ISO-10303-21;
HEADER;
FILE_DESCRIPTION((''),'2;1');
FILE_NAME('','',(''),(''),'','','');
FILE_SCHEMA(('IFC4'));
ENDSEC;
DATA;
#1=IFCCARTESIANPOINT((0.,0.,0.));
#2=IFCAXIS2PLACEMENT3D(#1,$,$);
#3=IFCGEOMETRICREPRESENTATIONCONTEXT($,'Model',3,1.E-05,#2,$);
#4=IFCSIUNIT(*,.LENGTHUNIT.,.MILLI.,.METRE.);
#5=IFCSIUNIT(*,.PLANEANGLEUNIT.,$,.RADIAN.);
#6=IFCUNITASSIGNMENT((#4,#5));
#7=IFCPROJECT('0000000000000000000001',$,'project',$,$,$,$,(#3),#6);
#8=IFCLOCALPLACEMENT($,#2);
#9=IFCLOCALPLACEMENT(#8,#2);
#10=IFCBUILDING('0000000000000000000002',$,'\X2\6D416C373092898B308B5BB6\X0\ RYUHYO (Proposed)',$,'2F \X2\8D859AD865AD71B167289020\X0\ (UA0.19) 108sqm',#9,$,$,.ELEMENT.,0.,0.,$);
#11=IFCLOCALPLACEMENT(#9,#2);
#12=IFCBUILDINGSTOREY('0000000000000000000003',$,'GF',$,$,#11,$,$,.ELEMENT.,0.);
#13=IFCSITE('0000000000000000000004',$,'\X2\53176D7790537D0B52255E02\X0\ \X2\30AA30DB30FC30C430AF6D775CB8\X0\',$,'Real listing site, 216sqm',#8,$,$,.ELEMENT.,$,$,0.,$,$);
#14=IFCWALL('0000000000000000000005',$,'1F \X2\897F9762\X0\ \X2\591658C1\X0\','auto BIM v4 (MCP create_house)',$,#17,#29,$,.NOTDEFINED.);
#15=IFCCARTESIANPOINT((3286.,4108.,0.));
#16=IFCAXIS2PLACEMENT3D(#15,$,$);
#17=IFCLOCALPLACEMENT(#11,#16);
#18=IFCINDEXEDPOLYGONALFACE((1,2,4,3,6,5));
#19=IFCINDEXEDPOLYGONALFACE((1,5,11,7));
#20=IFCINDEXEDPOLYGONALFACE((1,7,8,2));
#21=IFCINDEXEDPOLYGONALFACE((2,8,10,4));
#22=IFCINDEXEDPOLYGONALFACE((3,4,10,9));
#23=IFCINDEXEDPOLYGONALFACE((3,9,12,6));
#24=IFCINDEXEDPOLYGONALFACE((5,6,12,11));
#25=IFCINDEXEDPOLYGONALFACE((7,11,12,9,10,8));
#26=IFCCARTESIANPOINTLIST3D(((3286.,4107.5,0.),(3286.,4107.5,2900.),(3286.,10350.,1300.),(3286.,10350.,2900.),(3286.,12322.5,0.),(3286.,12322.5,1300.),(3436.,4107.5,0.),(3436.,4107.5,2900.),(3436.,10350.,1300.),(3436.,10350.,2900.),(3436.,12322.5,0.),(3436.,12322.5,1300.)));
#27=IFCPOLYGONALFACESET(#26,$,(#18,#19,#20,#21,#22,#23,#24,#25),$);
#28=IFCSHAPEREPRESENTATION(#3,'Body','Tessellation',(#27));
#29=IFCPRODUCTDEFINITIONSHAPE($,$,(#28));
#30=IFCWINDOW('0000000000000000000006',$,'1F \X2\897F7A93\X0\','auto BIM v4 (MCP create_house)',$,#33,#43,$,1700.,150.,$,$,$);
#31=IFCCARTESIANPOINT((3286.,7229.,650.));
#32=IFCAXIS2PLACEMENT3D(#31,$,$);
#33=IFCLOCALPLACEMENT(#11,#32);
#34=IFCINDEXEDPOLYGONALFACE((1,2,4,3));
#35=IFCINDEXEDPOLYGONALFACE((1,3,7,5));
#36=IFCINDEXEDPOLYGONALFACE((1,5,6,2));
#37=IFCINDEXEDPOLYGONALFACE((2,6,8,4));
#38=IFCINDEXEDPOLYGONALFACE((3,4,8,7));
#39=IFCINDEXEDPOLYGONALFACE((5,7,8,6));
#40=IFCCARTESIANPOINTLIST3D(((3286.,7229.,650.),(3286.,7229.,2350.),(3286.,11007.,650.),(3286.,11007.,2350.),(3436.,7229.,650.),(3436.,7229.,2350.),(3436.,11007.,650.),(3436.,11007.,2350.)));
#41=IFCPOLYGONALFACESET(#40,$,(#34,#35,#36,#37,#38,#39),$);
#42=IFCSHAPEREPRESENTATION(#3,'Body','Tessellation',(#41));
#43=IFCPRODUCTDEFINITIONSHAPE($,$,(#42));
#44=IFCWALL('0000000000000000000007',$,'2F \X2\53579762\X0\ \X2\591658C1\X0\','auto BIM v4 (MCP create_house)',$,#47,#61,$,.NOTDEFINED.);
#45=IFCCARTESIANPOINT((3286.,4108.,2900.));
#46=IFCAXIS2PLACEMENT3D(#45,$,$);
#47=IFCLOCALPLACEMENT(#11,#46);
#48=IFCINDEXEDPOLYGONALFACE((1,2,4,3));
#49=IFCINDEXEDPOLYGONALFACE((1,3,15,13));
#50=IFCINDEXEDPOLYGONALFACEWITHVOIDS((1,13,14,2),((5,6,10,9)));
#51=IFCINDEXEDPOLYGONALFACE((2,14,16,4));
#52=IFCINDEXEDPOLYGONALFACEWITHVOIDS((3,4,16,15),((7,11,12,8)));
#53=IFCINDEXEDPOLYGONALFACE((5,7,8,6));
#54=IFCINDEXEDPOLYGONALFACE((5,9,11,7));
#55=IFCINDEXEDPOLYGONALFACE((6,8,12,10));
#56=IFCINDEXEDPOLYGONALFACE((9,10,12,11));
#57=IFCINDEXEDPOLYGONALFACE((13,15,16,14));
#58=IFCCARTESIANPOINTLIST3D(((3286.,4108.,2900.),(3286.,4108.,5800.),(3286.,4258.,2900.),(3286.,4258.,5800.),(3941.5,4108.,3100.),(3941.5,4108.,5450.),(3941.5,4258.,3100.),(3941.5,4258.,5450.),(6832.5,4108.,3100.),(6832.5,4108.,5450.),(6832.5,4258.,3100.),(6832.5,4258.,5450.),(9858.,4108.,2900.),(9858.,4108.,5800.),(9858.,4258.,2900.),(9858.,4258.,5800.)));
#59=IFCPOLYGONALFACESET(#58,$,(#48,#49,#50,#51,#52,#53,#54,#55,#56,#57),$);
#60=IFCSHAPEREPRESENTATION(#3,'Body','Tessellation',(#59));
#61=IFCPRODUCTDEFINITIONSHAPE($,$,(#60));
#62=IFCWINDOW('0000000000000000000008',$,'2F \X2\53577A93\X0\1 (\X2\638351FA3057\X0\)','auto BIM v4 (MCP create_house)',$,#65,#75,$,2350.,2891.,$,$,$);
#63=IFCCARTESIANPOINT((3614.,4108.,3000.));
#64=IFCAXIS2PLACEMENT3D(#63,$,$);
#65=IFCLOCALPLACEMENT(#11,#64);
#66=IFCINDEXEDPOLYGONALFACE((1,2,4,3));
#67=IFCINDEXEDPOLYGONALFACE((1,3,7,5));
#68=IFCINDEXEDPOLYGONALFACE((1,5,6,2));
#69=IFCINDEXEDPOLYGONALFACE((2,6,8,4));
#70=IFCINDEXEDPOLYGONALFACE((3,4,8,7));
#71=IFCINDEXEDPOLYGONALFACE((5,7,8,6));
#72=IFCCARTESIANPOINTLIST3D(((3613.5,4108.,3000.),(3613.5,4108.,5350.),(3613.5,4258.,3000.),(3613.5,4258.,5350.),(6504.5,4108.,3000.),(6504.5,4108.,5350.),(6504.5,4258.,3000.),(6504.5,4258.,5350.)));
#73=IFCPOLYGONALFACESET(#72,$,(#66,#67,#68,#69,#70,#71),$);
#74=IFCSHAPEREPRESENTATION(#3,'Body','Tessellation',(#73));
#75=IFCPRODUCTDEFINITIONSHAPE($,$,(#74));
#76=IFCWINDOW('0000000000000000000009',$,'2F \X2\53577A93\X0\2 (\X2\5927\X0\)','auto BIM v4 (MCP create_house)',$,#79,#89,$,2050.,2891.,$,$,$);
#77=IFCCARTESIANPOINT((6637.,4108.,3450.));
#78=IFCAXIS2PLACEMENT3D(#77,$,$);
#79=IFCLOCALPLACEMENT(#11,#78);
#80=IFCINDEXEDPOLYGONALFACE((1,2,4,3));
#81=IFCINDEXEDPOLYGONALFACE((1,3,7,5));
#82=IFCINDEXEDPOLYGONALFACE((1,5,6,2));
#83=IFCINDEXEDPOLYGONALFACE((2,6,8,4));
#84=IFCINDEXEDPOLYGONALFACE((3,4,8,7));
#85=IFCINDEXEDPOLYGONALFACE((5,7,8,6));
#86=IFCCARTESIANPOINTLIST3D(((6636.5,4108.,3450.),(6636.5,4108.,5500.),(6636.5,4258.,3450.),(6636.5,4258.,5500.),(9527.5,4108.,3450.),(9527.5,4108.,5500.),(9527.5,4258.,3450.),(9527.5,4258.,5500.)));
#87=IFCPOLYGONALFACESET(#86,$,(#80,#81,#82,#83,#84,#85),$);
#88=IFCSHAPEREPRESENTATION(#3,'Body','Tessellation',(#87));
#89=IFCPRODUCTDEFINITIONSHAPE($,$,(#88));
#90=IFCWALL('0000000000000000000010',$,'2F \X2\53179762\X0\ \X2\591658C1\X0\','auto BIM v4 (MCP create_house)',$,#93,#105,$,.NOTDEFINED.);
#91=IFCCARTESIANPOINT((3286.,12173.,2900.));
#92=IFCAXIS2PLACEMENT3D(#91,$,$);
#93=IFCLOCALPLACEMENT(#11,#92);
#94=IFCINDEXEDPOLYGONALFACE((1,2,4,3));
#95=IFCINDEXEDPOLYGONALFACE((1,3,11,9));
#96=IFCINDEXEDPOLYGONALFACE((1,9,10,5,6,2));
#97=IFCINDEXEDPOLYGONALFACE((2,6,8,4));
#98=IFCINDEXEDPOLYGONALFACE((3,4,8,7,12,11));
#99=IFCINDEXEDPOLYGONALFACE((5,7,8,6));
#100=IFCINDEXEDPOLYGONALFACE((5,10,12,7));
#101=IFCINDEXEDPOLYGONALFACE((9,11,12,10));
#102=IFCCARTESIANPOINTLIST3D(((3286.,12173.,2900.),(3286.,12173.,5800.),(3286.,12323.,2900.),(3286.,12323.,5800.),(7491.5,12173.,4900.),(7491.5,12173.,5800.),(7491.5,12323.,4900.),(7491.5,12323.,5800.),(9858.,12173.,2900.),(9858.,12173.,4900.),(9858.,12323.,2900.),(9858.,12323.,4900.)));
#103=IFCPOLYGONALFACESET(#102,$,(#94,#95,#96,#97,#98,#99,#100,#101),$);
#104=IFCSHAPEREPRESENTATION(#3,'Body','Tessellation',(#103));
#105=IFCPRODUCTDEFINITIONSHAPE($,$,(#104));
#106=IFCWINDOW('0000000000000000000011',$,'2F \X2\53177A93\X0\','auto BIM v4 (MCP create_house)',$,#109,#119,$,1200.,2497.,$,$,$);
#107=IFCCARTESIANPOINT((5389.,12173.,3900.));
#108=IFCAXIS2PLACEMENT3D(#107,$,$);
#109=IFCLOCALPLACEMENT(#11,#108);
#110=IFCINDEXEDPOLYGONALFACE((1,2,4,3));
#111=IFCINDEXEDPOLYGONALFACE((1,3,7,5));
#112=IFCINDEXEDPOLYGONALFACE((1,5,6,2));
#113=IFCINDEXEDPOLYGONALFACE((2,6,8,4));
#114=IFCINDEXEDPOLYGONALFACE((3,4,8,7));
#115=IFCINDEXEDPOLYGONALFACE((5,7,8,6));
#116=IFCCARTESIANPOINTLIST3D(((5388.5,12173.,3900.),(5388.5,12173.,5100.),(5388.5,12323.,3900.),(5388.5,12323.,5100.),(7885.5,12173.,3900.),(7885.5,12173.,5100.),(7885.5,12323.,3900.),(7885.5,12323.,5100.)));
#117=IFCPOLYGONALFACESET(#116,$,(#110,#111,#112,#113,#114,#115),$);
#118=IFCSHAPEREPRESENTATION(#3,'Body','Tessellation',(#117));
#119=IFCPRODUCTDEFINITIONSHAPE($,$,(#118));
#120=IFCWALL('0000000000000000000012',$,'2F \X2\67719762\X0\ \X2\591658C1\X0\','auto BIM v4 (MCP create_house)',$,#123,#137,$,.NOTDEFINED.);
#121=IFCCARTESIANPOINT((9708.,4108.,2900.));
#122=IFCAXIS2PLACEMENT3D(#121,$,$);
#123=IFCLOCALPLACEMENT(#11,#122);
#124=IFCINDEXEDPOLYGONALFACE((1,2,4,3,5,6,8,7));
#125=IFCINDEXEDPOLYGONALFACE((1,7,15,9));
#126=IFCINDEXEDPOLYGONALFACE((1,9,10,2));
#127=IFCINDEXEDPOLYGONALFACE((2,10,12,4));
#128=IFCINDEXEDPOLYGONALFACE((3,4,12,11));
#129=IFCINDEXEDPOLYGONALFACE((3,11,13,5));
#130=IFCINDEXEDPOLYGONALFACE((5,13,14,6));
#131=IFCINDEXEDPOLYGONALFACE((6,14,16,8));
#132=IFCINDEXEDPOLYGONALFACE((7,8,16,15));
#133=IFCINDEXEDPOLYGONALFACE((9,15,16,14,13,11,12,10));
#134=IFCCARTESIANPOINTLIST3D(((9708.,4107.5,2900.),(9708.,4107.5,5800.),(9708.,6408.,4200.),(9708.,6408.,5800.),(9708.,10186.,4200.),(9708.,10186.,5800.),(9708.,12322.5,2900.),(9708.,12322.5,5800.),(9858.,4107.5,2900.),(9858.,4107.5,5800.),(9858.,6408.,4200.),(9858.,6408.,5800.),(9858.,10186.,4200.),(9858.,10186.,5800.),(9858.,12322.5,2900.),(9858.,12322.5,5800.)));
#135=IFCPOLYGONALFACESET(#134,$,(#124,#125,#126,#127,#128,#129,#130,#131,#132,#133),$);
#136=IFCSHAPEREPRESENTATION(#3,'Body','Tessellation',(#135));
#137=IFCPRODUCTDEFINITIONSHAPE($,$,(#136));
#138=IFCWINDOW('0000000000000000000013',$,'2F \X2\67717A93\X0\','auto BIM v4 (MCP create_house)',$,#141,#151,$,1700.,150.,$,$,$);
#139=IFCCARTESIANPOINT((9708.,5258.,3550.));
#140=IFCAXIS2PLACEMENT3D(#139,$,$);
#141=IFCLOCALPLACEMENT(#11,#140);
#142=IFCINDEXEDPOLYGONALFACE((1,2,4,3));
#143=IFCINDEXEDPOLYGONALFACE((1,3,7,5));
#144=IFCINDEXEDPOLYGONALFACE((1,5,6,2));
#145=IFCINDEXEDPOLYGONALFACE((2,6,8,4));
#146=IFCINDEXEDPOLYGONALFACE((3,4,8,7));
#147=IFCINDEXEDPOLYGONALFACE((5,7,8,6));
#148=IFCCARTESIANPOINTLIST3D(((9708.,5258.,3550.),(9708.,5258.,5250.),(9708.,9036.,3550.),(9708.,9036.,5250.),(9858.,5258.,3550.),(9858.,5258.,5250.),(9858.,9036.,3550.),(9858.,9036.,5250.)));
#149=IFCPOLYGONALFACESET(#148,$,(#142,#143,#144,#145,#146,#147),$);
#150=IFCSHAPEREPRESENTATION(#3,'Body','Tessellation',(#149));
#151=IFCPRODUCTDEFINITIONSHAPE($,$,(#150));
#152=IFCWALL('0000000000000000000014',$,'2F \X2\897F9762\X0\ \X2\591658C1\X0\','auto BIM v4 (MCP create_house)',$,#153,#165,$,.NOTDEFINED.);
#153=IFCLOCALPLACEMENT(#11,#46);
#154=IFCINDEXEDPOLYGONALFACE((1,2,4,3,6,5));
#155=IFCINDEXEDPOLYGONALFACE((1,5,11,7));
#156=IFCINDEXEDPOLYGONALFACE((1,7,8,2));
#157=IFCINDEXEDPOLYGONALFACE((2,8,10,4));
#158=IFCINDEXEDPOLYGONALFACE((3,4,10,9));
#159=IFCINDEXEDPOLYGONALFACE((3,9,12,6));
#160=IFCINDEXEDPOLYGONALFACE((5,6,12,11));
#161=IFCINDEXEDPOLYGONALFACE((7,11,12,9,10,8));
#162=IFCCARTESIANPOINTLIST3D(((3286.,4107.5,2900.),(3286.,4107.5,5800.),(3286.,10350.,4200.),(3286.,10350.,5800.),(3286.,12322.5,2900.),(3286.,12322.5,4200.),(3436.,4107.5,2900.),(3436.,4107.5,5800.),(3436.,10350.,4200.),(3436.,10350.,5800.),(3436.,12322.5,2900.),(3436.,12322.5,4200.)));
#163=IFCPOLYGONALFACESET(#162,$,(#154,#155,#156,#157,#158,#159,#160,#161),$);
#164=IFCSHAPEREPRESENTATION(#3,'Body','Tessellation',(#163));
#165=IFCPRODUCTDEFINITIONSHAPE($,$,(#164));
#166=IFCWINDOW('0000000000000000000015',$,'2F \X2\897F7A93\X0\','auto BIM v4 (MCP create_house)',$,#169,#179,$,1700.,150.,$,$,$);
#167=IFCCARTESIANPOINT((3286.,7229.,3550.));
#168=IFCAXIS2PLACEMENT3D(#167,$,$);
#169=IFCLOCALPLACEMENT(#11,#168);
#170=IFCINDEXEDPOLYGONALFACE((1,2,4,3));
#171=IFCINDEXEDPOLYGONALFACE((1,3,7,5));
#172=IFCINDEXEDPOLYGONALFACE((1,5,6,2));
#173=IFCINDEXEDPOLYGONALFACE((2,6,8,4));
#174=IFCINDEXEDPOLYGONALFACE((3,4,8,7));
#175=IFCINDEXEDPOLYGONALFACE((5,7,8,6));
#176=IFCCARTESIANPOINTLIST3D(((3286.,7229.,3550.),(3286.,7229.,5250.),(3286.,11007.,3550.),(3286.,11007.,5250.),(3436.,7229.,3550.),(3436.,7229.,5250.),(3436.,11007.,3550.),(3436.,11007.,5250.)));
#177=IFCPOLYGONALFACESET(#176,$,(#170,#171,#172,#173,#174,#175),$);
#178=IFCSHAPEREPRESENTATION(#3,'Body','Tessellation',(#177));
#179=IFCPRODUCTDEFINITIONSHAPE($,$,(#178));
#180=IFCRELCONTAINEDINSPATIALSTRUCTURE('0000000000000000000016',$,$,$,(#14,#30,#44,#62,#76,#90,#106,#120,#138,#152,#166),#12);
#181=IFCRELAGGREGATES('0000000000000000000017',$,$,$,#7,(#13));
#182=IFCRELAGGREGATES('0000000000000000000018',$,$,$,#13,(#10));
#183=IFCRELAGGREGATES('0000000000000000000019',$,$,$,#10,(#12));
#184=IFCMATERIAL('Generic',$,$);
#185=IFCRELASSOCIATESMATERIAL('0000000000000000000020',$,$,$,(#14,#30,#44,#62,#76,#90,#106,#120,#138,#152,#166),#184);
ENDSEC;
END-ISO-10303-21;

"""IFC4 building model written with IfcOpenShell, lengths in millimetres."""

from ifc_helpers import new_model, si_unit, frame, frame_2d, origin, place, context, project, spatial, rectangle, extrude, material, element, fill, save


model = new_model("IFC4")

# Units and contexts
model_context = context("Model", 3, precision=1e-05, world=origin())
ifc_project = project(units=[si_unit("LENGTHUNIT", "METRE", prefix="MILLI"), si_unit("PLANEANGLEUNIT", "RADIAN")], contexts=[model_context])

# Site, building, storey
site_placement = place(None, origin())
site = spatial("IfcSite", under=ifc_project, at=site_placement, Name="北海道紋別市 オホーツク海岸", ObjectType="Real listing site, 216sqm", CompositionType="ELEMENT", RefElevation=0.0)
building_placement = place(site_placement, origin())
building = spatial("IfcBuilding", under=site, at=building_placement, Name="流氷を見る家 RYUHYO (Proposed)", ObjectType="2F 超高断熱木造 (UA0.19) 108sqm", CompositionType="ELEMENT", ElevationOfRefHeight=0.0, ElevationOfTerrain=0.0)
storey_placement = place(building_placement, origin())
storey = spatial("IfcBuildingStorey", under=building, at=storey_placement, Name="GF", CompositionType="ELEMENT", Elevation=0.0)

# Shared definitions
ifc_material = material(Name="Generic")

# Wall, opening, window
wall_1_placement = place(storey_placement, frame((3286.0, 4108.0, 0.0)))
wall_1 = element("IfcWall", 1, at=wall_1_placement, inside=storey, material=ifc_material, Name="1F 西面 外壁", Description="auto BIM v4 (MCP create_house)", PredefinedType="NOTDEFINED", context=model_context, shape_type="SweptSolid", body=[
    extrude(rectangle(XDim=150.0, YDim=8215.0, at=frame_2d((75.0, 4107.0))), frame((3286.0, 4108.0, 0.0)), (0.0, 0.0, 1.0), 2900.0),
])
opening_1_placement = place(storey_placement, frame((3286.0, 7229.0, 650.0)))
opening_1 = element("IfcOpeningElement", 2, at=opening_1_placement, cuts=wall_1, PredefinedType="NOTDEFINED", context=model_context, shape_type="SweptSolid", body=[
    extrude(rectangle(XDim=150.0, YDim=3778.0, at=frame_2d((75.0, 1889.0))), frame((3286.0, 7229.0, 650.0)), (0.0, 0.0, 1.0), 1700.0),
])
window_1_placement = place(storey_placement, frame((3286.0, 7229.0, 650.0)))
window_1 = element("IfcWindow", 3, at=window_1_placement, inside=storey, material=ifc_material, Name="1F 西窓", Description="auto BIM v4 (MCP create_house)", OverallHeight=1700.0, OverallWidth=150.0, context=model_context, shape_type="SweptSolid", body=[
    extrude(rectangle(XDim=150.0, YDim=3778.0, at=frame_2d((75.0, 1889.0))), frame((3286.0, 7229.0, 650.0)), (0.0, 0.0, 1.0), 1700.0),
])
fill(opening_1, window_1)

# Wall, openings, windows
wall_2_placement = place(storey_placement, frame((3286.0, 4108.0, 2900.0)))
wall_2 = element("IfcWall", 4, at=wall_2_placement, inside=storey, material=ifc_material, Name="2F 南面 外壁", Description="auto BIM v4 (MCP create_house)", PredefinedType="NOTDEFINED", context=model_context, shape_type="SweptSolid", body=[
    extrude(rectangle(XDim=6572.0, YDim=150.0, at=frame_2d((3286.0, 75.0))), frame((3286.0, 4108.0, 2900.0)), (0.0, 0.0, 1.0), 2900.0),
])
opening_2_placement = place(storey_placement, frame((3614.0, 4108.0, 3000.0)))
opening_2 = element("IfcOpeningElement", 5, at=opening_2_placement, cuts=wall_2, PredefinedType="NOTDEFINED", context=model_context, shape_type="SweptSolid", body=[
    extrude(rectangle(XDim=2891.0, YDim=150.0, at=frame_2d((1445.0, 75.0))), frame((3614.0, 4108.0, 3000.0)), (0.0, 0.0, 1.0), 2350.0),
])
opening_3_placement = place(storey_placement, frame((6637.0, 4108.0, 3450.0)))
opening_3 = element("IfcOpeningElement", 6, at=opening_3_placement, cuts=wall_2, PredefinedType="NOTDEFINED", context=model_context, shape_type="SweptSolid", body=[
    extrude(rectangle(XDim=2891.0, YDim=150.0, at=frame_2d((1445.0, 75.0))), frame((6637.0, 4108.0, 3450.0)), (0.0, 0.0, 1.0), 2050.0),
])
window_2_placement = place(storey_placement, frame((3614.0, 4108.0, 3000.0)))
window_2 = element("IfcWindow", 7, at=window_2_placement, inside=storey, material=ifc_material, Name="2F 南窓1 (掃出し)", Description="auto BIM v4 (MCP create_house)", OverallHeight=2350.0, OverallWidth=2891.0, context=model_context, shape_type="SweptSolid", body=[
    extrude(rectangle(XDim=2891.0, YDim=150.0, at=frame_2d((1445.0, 75.0))), frame((3614.0, 4108.0, 3000.0)), (0.0, 0.0, 1.0), 2350.0),
])
fill(opening_2, window_2)
window_3_placement = place(storey_placement, frame((6637.0, 4108.0, 3450.0)))
window_3 = element("IfcWindow", 8, at=window_3_placement, inside=storey, material=ifc_material, Name="2F 南窓2 (大)", Description="auto BIM v4 (MCP create_house)", OverallHeight=2050.0, OverallWidth=2891.0, context=model_context, shape_type="SweptSolid", body=[
    extrude(rectangle(XDim=2891.0, YDim=150.0, at=frame_2d((1445.0, 75.0))), frame((6637.0, 4108.0, 3450.0)), (0.0, 0.0, 1.0), 2050.0),
])
fill(opening_3, window_3)

# Walls, openings, windows
wall_3_placement = place(storey_placement, frame((3286.0, 12173.0, 2900.0)))
wall_3 = element("IfcWall", 9, at=wall_3_placement, inside=storey, material=ifc_material, Name="2F 北面 外壁", Description="auto BIM v4 (MCP create_house)", PredefinedType="NOTDEFINED", context=model_context, shape_type="SweptSolid", body=[
    extrude(rectangle(XDim=6572.0, YDim=150.0, at=frame_2d((3286.0, 75.0))), frame((3286.0, 12173.0, 2900.0)), (0.0, 0.0, 1.0), 2900.0),
])
opening_4_placement = place(storey_placement, frame((5389.0, 12173.0, 3900.0)))
opening_4 = element("IfcOpeningElement", 10, at=opening_4_placement, cuts=wall_3, PredefinedType="NOTDEFINED", context=model_context, shape_type="SweptSolid", body=[
    extrude(rectangle(XDim=2497.0, YDim=150.0, at=frame_2d((1248.0, 75.0))), frame((5389.0, 12173.0, 3900.0)), (0.0, 0.0, 1.0), 1200.0),
])
window_4_placement = place(storey_placement, frame((5389.0, 12173.0, 3900.0)))
window_4 = element("IfcWindow", 11, at=window_4_placement, inside=storey, material=ifc_material, Name="2F 北窓", Description="auto BIM v4 (MCP create_house)", OverallHeight=1200.0, OverallWidth=2497.0, context=model_context, shape_type="SweptSolid", body=[
    extrude(rectangle(XDim=2497.0, YDim=150.0, at=frame_2d((1248.0, 75.0))), frame((5389.0, 12173.0, 3900.0)), (0.0, 0.0, 1.0), 1200.0),
])
fill(opening_4, window_4)
wall_4_placement = place(storey_placement, frame((9708.0, 4108.0, 2900.0)))
wall_4 = element("IfcWall", 12, at=wall_4_placement, inside=storey, material=ifc_material, Name="2F 東面 外壁", Description="auto BIM v4 (MCP create_house)", PredefinedType="NOTDEFINED", context=model_context, shape_type="SweptSolid", body=[
    extrude(rectangle(XDim=150.0, YDim=8215.0, at=frame_2d((75.0, 4107.0))), frame((9708.0, 4108.0, 2900.0)), (0.0, 0.0, 1.0), 2900.0),
])
opening_5_placement = place(storey_placement, frame((9708.0, 5258.0, 3550.0)))
opening_5 = element("IfcOpeningElement", 13, at=opening_5_placement, cuts=wall_4, PredefinedType="NOTDEFINED", context=model_context, shape_type="SweptSolid", body=[
    extrude(rectangle(XDim=150.0, YDim=3778.0, at=frame_2d((75.0, 1889.0))), frame((9708.0, 5258.0, 3550.0)), (0.0, 0.0, 1.0), 1700.0),
])
window_5_placement = place(storey_placement, frame((9708.0, 5258.0, 3550.0)))
window_5 = element("IfcWindow", 14, at=window_5_placement, inside=storey, material=ifc_material, Name="2F 東窓", Description="auto BIM v4 (MCP create_house)", OverallHeight=1700.0, OverallWidth=150.0, context=model_context, shape_type="SweptSolid", body=[
    extrude(rectangle(XDim=150.0, YDim=3778.0, at=frame_2d((75.0, 1889.0))), frame((9708.0, 5258.0, 3550.0)), (0.0, 0.0, 1.0), 1700.0),
])
fill(opening_5, window_5)
wall_5_placement = place(storey_placement, frame((3286.0, 4108.0, 2900.0)))
wall_5 = element("IfcWall", 15, at=wall_5_placement, inside=storey, material=ifc_material, Name="2F 西面 外壁", Description="auto BIM v4 (MCP create_house)", PredefinedType="NOTDEFINED", context=model_context, shape_type="SweptSolid", body=[
    extrude(rectangle(XDim=150.0, YDim=8215.0, at=frame_2d((75.0, 4107.0))), frame((3286.0, 4108.0, 2900.0)), (0.0, 0.0, 1.0), 2900.0),
])
opening_6_placement = place(storey_placement, frame((3286.0, 7229.0, 3550.0)))
opening_6 = element("IfcOpeningElement", 16, at=opening_6_placement, cuts=wall_5, PredefinedType="NOTDEFINED", context=model_context, shape_type="SweptSolid", body=[
    extrude(rectangle(XDim=150.0, YDim=3778.0, at=frame_2d((75.0, 1889.0))), frame((3286.0, 7229.0, 3550.0)), (0.0, 0.0, 1.0), 1700.0),
])
window_6_placement = place(storey_placement, frame((3286.0, 7229.0, 3550.0)))
window_6 = element("IfcWindow", 17, at=window_6_placement, inside=storey, material=ifc_material, Name="2F 西窓", Description="auto BIM v4 (MCP create_house)", OverallHeight=1700.0, OverallWidth=150.0, context=model_context, shape_type="SweptSolid", body=[
    extrude(rectangle(XDim=150.0, YDim=3778.0, at=frame_2d((75.0, 1889.0))), frame((3286.0, 7229.0, 3550.0)), (0.0, 0.0, 1.0), 1700.0),
])
fill(opening_6, window_6)

save(model, "model.ifc")
